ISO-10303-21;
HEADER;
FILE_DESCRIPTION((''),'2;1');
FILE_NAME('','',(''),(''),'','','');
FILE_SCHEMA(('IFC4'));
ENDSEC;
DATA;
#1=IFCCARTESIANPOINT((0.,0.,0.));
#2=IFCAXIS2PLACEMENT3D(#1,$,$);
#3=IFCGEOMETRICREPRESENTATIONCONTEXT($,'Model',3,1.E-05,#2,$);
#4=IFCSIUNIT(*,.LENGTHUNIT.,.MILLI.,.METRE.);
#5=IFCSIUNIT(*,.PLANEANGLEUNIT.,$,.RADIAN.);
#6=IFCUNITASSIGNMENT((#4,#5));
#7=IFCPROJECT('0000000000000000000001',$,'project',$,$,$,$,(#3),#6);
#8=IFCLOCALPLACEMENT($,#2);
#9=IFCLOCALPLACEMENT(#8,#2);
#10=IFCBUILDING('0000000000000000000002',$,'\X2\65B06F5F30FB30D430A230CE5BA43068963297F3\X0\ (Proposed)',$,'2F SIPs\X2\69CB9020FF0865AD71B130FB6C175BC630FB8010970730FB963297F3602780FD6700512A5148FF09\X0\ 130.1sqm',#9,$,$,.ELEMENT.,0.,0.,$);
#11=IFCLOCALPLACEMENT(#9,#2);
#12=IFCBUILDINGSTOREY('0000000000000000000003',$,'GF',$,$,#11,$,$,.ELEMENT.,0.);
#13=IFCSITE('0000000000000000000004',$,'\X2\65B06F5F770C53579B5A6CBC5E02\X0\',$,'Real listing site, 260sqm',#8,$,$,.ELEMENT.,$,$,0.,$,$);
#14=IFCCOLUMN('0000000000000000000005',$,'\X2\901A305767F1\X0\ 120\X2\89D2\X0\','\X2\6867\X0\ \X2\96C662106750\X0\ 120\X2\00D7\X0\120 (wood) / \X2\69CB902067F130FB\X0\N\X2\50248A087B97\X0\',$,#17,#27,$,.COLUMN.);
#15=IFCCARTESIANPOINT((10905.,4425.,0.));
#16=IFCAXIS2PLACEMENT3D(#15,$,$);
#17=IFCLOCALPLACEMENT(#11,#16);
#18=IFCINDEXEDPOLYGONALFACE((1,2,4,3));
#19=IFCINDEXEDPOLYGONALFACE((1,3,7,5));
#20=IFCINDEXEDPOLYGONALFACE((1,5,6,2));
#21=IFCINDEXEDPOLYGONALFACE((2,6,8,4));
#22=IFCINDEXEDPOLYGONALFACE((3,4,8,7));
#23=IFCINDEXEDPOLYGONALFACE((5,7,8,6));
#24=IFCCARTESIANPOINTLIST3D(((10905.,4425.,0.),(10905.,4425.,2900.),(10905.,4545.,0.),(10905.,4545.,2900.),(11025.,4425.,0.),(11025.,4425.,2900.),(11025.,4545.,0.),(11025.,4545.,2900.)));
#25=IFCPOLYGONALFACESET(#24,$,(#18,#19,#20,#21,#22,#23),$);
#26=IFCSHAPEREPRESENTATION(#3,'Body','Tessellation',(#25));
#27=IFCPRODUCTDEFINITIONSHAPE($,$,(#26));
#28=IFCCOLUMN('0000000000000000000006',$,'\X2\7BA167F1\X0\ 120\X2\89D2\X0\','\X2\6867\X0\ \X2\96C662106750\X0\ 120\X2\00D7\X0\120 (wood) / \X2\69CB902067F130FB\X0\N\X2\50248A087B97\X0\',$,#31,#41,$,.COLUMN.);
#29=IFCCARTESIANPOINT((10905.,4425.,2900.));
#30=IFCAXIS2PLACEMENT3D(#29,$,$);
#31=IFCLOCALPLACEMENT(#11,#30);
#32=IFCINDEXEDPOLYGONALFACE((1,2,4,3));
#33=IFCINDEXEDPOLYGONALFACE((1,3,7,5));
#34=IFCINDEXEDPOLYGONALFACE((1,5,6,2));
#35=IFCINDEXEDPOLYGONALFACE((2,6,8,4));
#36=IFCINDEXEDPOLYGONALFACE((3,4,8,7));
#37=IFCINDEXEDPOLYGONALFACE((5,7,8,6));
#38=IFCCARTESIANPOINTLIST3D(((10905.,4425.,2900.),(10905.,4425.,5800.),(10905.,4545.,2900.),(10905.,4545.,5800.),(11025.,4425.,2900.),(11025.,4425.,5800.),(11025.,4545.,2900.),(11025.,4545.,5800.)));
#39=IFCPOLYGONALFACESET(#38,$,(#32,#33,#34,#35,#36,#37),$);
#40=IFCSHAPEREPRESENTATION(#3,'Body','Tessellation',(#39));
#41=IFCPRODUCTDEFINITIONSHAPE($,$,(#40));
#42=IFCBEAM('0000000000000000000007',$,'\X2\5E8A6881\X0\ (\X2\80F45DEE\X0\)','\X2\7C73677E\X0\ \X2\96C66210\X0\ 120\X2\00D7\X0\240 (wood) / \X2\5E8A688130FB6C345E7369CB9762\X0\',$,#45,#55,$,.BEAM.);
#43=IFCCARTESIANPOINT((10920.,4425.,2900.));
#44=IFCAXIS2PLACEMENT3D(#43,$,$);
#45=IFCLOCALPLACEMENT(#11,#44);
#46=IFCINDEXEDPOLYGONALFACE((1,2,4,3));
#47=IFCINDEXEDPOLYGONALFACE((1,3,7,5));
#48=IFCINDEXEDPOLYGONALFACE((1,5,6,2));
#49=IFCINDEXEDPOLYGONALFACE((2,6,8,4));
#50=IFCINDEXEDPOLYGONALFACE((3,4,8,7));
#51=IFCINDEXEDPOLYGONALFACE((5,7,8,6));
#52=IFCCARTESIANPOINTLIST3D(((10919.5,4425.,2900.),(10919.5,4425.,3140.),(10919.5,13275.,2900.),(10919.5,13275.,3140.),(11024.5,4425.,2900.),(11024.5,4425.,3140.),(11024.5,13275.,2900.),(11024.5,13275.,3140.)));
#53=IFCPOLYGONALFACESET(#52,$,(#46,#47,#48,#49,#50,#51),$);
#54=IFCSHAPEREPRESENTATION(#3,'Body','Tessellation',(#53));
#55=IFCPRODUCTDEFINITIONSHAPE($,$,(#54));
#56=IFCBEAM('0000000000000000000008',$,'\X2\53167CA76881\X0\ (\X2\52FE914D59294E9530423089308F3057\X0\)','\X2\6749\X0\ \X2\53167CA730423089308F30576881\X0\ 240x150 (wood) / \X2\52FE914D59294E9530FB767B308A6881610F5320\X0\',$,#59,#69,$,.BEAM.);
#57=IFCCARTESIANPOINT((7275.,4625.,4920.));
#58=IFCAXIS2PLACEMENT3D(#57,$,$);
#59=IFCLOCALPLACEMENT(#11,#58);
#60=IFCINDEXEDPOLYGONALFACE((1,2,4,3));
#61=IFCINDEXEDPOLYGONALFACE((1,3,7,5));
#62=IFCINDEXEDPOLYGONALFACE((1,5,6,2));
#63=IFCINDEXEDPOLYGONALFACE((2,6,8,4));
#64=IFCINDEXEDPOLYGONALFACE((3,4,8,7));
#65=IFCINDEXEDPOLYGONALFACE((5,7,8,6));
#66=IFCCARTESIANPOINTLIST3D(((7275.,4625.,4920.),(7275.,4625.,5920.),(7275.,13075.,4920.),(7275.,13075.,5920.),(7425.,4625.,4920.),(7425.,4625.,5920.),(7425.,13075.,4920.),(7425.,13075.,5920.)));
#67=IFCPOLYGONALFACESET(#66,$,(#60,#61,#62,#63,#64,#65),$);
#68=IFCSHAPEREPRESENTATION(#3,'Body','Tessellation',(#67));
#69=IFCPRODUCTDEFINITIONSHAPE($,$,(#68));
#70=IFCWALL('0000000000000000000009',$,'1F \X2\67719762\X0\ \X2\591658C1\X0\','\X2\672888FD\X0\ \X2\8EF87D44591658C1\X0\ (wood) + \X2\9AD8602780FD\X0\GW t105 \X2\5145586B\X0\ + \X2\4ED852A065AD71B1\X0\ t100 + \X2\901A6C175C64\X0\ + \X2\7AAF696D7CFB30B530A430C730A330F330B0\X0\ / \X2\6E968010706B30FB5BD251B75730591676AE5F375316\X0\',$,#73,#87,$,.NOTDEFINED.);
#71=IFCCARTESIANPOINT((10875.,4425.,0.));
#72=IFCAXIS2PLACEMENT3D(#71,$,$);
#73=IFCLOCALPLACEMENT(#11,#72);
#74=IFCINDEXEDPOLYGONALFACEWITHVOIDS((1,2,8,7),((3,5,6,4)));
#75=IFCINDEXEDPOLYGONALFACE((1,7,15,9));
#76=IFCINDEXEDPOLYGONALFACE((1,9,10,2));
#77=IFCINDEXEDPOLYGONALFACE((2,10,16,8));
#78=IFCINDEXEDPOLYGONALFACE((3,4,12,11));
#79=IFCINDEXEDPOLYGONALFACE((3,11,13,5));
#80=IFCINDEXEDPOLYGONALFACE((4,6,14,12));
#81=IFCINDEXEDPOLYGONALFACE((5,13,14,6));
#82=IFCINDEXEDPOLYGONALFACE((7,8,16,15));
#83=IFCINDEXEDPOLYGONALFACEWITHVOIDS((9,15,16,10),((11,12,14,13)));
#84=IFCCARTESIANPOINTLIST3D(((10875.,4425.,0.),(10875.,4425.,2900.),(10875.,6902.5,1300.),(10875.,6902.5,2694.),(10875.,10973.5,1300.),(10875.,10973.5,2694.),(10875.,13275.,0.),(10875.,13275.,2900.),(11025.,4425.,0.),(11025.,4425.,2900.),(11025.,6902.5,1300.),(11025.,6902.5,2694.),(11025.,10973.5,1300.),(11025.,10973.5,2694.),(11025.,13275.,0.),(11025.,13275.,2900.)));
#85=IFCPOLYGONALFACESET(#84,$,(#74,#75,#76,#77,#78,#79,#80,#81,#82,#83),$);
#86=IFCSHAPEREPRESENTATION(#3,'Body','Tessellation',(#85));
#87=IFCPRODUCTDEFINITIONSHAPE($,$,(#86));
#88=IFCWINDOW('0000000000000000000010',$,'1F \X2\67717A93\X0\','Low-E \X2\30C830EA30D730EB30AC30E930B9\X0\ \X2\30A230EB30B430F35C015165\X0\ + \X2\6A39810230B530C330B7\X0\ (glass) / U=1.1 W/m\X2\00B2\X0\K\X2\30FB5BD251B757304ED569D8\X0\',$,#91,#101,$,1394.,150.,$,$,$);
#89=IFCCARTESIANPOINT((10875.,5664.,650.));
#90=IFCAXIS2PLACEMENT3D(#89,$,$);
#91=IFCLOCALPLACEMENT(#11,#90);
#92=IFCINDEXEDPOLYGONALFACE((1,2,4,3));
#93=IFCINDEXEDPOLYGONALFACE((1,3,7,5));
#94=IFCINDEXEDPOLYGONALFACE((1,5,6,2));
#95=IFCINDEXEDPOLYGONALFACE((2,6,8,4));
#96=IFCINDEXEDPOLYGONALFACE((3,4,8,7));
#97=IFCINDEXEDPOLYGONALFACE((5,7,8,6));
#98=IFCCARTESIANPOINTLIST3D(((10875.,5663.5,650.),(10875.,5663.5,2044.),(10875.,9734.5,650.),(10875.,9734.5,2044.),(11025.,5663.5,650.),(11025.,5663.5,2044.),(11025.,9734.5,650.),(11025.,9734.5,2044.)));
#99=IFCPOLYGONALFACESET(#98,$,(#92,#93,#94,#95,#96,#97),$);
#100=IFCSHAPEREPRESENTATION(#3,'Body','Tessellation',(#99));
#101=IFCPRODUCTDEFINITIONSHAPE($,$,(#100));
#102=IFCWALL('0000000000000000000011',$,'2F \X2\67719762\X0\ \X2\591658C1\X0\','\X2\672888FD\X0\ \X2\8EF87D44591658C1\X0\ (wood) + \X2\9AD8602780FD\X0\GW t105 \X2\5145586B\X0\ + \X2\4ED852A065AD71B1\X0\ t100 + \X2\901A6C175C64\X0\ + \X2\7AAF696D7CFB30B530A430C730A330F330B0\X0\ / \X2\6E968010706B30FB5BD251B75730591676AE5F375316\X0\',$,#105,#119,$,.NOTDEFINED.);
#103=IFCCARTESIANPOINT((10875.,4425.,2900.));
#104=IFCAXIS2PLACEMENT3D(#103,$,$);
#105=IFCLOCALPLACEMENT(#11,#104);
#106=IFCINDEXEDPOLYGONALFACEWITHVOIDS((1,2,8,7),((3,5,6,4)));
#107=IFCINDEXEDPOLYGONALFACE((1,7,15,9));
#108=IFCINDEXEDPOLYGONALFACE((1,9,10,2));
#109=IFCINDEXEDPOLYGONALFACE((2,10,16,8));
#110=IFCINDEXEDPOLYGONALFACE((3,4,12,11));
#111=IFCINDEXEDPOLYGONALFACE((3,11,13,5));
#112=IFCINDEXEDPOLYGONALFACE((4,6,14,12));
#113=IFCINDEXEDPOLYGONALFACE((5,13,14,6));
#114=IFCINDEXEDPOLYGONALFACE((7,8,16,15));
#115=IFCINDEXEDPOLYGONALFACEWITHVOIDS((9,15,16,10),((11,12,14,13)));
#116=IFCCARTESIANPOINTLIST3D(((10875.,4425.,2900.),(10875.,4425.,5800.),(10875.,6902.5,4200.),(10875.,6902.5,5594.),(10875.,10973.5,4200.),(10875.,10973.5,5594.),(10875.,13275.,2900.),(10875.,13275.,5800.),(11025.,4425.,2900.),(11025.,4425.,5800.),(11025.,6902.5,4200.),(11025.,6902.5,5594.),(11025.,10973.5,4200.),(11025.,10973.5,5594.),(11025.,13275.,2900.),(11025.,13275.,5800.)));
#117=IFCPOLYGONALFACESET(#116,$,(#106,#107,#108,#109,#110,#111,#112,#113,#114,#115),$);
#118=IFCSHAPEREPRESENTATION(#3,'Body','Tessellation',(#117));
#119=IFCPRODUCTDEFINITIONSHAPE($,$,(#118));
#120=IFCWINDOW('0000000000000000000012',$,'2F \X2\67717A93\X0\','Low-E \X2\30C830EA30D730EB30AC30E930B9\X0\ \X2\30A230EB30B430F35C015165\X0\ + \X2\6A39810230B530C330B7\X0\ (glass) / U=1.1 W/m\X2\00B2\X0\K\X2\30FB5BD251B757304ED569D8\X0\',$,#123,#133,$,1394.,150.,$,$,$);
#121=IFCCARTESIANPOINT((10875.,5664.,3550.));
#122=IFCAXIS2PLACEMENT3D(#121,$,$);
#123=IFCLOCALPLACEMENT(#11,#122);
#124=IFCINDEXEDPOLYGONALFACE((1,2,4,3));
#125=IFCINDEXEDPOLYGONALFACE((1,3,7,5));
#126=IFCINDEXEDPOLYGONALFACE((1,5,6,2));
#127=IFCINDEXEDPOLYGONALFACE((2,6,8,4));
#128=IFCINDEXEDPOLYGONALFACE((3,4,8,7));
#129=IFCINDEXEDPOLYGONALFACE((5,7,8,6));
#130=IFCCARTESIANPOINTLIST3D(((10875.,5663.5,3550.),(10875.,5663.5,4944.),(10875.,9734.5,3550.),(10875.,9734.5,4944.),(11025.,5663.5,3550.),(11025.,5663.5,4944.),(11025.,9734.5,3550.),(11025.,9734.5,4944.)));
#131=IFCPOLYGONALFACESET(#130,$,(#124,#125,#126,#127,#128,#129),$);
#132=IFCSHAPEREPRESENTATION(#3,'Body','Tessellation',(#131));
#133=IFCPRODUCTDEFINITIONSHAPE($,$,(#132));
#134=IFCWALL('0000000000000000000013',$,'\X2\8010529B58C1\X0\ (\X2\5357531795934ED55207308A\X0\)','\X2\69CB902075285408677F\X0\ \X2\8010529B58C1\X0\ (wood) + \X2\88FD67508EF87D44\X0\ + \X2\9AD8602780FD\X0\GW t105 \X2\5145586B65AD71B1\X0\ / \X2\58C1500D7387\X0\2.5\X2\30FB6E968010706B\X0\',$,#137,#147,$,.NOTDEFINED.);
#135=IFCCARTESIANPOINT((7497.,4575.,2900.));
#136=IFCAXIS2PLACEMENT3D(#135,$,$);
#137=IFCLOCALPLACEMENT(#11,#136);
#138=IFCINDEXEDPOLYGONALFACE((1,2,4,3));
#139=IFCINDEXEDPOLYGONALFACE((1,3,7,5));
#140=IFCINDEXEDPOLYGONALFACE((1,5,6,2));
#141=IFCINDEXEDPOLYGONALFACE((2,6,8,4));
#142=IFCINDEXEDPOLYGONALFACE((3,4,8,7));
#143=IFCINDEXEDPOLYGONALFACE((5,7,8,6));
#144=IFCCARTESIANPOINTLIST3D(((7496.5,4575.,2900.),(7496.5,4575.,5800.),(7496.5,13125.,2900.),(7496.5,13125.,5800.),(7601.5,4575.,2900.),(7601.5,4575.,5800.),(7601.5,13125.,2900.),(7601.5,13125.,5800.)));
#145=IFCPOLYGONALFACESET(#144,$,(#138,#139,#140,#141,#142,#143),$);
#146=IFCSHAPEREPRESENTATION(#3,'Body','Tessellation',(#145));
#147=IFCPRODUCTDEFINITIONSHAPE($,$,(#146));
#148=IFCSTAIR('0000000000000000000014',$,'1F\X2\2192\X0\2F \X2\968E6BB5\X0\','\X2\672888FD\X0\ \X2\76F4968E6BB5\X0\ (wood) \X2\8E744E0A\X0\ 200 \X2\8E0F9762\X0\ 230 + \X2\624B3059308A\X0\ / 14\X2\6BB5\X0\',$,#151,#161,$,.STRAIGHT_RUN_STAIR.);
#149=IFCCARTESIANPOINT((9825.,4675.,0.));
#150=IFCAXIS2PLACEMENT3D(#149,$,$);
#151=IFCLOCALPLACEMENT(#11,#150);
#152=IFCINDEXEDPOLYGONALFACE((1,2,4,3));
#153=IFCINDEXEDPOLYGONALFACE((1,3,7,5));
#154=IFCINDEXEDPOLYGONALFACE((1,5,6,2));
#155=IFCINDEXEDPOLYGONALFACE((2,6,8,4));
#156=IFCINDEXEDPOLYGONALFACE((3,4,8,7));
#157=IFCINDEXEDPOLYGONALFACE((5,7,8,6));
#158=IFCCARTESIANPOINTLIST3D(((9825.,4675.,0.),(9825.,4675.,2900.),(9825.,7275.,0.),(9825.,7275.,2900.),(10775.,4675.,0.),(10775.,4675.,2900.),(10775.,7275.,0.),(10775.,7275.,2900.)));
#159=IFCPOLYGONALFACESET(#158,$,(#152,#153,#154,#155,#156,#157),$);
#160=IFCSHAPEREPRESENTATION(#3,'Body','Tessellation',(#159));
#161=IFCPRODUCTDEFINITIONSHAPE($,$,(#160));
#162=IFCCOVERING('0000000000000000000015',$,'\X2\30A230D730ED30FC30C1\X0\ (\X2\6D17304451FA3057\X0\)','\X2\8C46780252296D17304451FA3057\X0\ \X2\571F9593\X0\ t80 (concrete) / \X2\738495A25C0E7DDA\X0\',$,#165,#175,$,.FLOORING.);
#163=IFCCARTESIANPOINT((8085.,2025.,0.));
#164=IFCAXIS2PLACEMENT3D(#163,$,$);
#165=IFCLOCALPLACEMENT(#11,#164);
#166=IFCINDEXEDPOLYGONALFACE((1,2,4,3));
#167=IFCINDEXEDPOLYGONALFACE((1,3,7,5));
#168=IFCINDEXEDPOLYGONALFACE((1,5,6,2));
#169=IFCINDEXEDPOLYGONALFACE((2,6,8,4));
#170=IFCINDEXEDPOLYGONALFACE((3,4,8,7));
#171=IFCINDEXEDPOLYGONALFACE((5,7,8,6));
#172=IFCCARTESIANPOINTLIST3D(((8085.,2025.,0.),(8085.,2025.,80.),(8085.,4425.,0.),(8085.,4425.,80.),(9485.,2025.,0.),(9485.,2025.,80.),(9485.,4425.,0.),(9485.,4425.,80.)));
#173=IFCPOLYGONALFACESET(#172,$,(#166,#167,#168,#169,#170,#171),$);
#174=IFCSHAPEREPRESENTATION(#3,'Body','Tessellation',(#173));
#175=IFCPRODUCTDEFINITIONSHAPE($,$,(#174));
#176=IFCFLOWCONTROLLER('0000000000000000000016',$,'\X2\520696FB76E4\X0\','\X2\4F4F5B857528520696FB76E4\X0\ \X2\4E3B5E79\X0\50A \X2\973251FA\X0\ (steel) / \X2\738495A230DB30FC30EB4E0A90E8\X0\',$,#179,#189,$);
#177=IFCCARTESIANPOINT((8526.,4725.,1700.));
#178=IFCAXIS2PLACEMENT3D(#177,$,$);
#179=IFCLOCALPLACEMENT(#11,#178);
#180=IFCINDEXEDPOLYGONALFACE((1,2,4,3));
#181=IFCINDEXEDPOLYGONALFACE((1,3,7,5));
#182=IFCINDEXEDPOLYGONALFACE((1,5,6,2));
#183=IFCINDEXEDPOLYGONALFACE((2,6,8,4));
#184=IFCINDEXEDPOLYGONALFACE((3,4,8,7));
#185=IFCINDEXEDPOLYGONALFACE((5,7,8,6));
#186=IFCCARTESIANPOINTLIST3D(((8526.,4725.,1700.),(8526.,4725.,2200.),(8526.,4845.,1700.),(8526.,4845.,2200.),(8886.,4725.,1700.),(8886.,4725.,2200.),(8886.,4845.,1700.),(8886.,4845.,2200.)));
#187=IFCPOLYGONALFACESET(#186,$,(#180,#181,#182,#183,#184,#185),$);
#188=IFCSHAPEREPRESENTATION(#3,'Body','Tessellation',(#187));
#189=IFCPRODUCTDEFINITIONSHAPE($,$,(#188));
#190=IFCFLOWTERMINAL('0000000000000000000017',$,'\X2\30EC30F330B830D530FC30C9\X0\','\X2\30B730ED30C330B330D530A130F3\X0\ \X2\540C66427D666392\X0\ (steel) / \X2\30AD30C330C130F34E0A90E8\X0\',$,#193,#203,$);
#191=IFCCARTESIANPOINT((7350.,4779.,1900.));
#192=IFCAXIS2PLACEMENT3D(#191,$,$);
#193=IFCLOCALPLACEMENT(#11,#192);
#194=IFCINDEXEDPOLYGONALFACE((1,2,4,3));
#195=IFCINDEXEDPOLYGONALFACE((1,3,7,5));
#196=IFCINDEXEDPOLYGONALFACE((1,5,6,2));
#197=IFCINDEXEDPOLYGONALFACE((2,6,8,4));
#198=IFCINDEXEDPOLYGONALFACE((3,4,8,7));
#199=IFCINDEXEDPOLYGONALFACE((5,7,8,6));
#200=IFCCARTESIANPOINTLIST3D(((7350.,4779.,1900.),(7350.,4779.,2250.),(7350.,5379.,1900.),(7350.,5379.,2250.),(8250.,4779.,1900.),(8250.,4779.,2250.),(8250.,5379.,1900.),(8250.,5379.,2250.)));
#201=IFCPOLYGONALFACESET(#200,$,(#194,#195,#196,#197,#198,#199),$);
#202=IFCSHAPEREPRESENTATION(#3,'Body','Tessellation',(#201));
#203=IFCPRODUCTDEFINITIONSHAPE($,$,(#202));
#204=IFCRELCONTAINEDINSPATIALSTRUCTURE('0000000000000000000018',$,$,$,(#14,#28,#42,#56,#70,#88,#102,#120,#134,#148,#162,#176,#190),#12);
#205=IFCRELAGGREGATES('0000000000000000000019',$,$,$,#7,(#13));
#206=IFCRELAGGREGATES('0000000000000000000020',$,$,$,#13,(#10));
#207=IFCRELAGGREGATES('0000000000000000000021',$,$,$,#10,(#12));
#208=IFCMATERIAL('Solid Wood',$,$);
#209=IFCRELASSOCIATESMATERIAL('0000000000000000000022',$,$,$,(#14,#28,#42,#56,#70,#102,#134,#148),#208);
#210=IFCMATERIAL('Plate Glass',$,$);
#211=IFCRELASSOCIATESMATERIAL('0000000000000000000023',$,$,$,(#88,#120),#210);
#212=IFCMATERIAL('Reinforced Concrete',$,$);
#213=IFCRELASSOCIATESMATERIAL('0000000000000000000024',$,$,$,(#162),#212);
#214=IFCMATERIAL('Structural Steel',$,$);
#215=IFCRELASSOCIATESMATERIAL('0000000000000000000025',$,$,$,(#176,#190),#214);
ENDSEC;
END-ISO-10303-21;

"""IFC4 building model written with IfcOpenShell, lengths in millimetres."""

from ifc_helpers import new_model, si_unit, frame, frame_2d, origin, place, context, project, spatial, rectangle, extrude, material, element, fill, save


model = new_model("IFC4")

# Units and contexts
model_context = context("Model", 3, precision=1e-05, world=origin())
ifc_project = project(units=[si_unit("LENGTHUNIT", "METRE", prefix="MILLI"), si_unit("PLANEANGLEUNIT", "RADIAN")], contexts=[model_context])

# Site, building, storey
site_placement = place(None, origin())
site = spatial("IfcSite", under=ifc_project, at=site_placement, Name="新潟県南魚沼市", ObjectType="Real listing site, 260sqm", CompositionType="ELEMENT", RefElevation=0.0)
building_placement = place(site_placement, origin())
building = spatial("IfcBuilding", under=site, at=building_placement, Name="新潟・ピアノ室と防音 (Proposed)", ObjectType="2F SIPs構造（断熱・気密・耐震・防音性能最優先） 130.1sqm", CompositionType="ELEMENT", ElevationOfRefHeight=0.0, ElevationOfTerrain=0.0)
storey_placement = place(building_placement, origin())
storey = spatial("IfcBuildingStorey", under=building, at=storey_placement, Name="GF", CompositionType="ELEMENT", Elevation=0.0)

# Columns
ifc_material_1 = material(Name="Solid Wood")
column_1_placement = place(storey_placement, frame((10905.0, 4425.0, 0.0)))
element("IfcColumn", 1, at=column_1_placement, inside=storey, material=ifc_material_1, Name="通し柱 120角", Description="桧 集成材 120×120 (wood) / 構造柱・N値計算", PredefinedType="COLUMN", context=model_context, shape_type="SweptSolid", body=[
    extrude(rectangle(XDim=120.0, YDim=120.0, at=frame_2d((60.0, 60.0))), frame((10905.0, 4425.0, 0.0)), (0.0, 0.0, 1.0), 2900.0),
])
column_2_placement = place(storey_placement, frame((10905.0, 4425.0, 2900.0)))
element("IfcColumn", 2, at=column_2_placement, inside=storey, material=ifc_material_1, Name="管柱 120角", Description="桧 集成材 120×120 (wood) / 構造柱・N値計算", PredefinedType="COLUMN", context=model_context, shape_type="SweptSolid", body=[
    extrude(rectangle(XDim=120.0, YDim=120.0, at=frame_2d((60.0, 60.0))), frame((10905.0, 4425.0, 2900.0)), (0.0, 0.0, 1.0), 2900.0),
])

# Beams
beam_1_placement = place(storey_placement, frame((10920.0, 4425.0, 2900.0)))
element("IfcBeam", 3, at=beam_1_placement, inside=storey, material=ifc_material_1, Name="床梁 (胴差)", Description="米松 集成 120×240 (wood) / 床梁・水平構面", PredefinedType="BEAM", context=model_context, shape_type="SweptSolid", body=[
    extrude(rectangle(XDim=105.0, YDim=8850.0, at=frame_2d((52.0, 4425.0))), frame((10920.0, 4425.0, 2900.0)), (0.0, 0.0, 1.0), 240.0),
])
beam_2_placement = place(storey_placement, frame((7275.0, 4625.0, 4920.0)))
element("IfcBeam", 4, at=beam_2_placement, inside=storey, material=ifc_material_1, Name="化粧梁 (勾配天井あらわし)", Description="杉 化粧あらわし梁 240x150 (wood) / 勾配天井・登り梁意匠", PredefinedType="BEAM", context=model_context, shape_type="SweptSolid", body=[
    extrude(rectangle(XDim=150.0, YDim=8450.0, at=frame_2d((75.0, 4225.0))), frame((7275.0, 4625.0, 4920.0)), (0.0, 0.0, 1.0), 1000.0),
])

# Wall, opening, window
wall_1_placement = place(storey_placement, frame((10875.0, 4425.0, 0.0)))
wall_1 = element("IfcWall", 5, at=wall_1_placement, inside=storey, material=ifc_material_1, Name="1F 東面 外壁", Description="木製 軸組外壁 (wood) + 高性能GW t105 充填 + 付加断熱 t100 + 通気層 + 窯業系サイディング / 準耐火・寒冷地外皮強化", PredefinedType="NOTDEFINED", context=model_context, shape_type="SweptSolid", body=[
    extrude(rectangle(XDim=150.0, YDim=8850.0, at=frame_2d((75.0, 4425.0))), frame((10875.0, 4425.0, 0.0)), (0.0, 0.0, 1.0), 2900.0),
])
opening_1_placement = place(storey_placement, frame((10875.0, 5664.0, 650.0)))
opening_1 = element("IfcOpeningElement", 6, at=opening_1_placement, cuts=wall_1, PredefinedType="NOTDEFINED", context=model_context, shape_type="SweptSolid", body=[
    extrude(rectangle(XDim=150.0, YDim=4071.0, at=frame_2d((75.0, 2035.0))), frame((10875.0, 5664.0, 650.0)), (0.0, 0.0, 1.0), 1394.0),
])
ifc_material_2 = material(Name="Plate Glass")
window_1_placement = place(storey_placement, frame((10875.0, 5664.0, 650.0)))
window_1 = element("IfcWindow", 7, at=window_1_placement, inside=storey, material=ifc_material_2, Name="1F 東窓", Description="Low-E トリプルガラス アルゴン封入 + 樹脂サッシ (glass) / U=1.1 W/m²K・寒冷地仕様", OverallHeight=1394.0, OverallWidth=150.0, context=model_context, shape_type="SweptSolid", body=[
    extrude(rectangle(XDim=150.0, YDim=4071.0, at=frame_2d((75.0, 2035.0))), frame((10875.0, 5664.0, 650.0)), (0.0, 0.0, 1.0), 1394.0),
])
fill(opening_1, window_1)

# Wall, opening, window
wall_2_placement = place(storey_placement, frame((10875.0, 4425.0, 2900.0)))
wall_2 = element("IfcWall", 8, at=wall_2_placement, inside=storey, material=ifc_material_1, Name="2F 東面 外壁", Description="木製 軸組外壁 (wood) + 高性能GW t105 充填 + 付加断熱 t100 + 通気層 + 窯業系サイディング / 準耐火・寒冷地外皮強化", PredefinedType="NOTDEFINED", context=model_context, shape_type="SweptSolid", body=[
    extrude(rectangle(XDim=150.0, YDim=8850.0, at=frame_2d((75.0, 4425.0))), frame((10875.0, 4425.0, 2900.0)), (0.0, 0.0, 1.0), 2900.0),
])
opening_2_placement = place(storey_placement, frame((10875.0, 5664.0, 3550.0)))
opening_2 = element("IfcOpeningElement", 9, at=opening_2_placement, cuts=wall_2, PredefinedType="NOTDEFINED", context=model_context, shape_type="SweptSolid", body=[
    extrude(rectangle(XDim=150.0, YDim=4071.0, at=frame_2d((75.0, 2035.0))), frame((10875.0, 5664.0, 3550.0)), (0.0, 0.0, 1.0), 1394.0),
])
window_2_placement = place(storey_placement, frame((10875.0, 5664.0, 3550.0)))
window_2 = element("IfcWindow", 10, at=window_2_placement, inside=storey, material=ifc_material_2, Name="2F 東窓", Description="Low-E トリプルガラス アルゴン封入 + 樹脂サッシ (glass) / U=1.1 W/m²K・寒冷地仕様", OverallHeight=1394.0, OverallWidth=150.0, context=model_context, shape_type="SweptSolid", body=[
    extrude(rectangle(XDim=150.0, YDim=4071.0, at=frame_2d((75.0, 2035.0))), frame((10875.0, 5664.0, 3550.0)), (0.0, 0.0, 1.0), 1394.0),
])
fill(opening_2, window_2)

# Wall
wall_3_placement = place(storey_placement, frame((7497.0, 4575.0, 2900.0)))
element("IfcWall", 11, at=wall_3_placement, inside=storey, material=ifc_material_1, Name="耐力壁 (南北間仕切り)", Description="構造用合板 耐力壁 (wood) + 製材軸組 + 高性能GW t105 充填断熱 / 壁倍率2.5・準耐火", PredefinedType="NOTDEFINED", context=model_context, shape_type="SweptSolid", body=[
    extrude(rectangle(XDim=105.0, YDim=8550.0, at=frame_2d((52.0, 4275.0))), frame((7497.0, 4575.0, 2900.0)), (0.0, 0.0, 1.0), 2900.0),
])

# Stair
stair_placement = place(storey_placement, frame((9825.0, 4675.0, 0.0)))
element("IfcStair", 12, at=stair_placement, inside=storey, material=ifc_material_1, Name="1F→2F 階段", Description="木製 直階段 (wood) 蹴上 200 踏面 230 + 手すり / 14段", PredefinedType="STRAIGHT_RUN_STAIR", context=model_context, shape_type="SweptSolid", body=[
    extrude(rectangle(XDim=950.0, YDim=2600.0, at=frame_2d((475.0, 1300.0))), frame((9825.0, 4675.0, 0.0)), (0.0, 0.0, 1.0), 2900.0),
])

# Covering
ifc_material_3 = material(Name="Reinforced Concrete")
covering_placement = place(storey_placement, frame((8085.0, 2025.0, 0.0)))
element("IfcCovering", 13, at=covering_placement, inside=storey, material=ifc_material_3, Name="アプローチ (洗い出し)", Description="豆砂利洗い出し 土間 t80 (concrete) / 玄関導線", PredefinedType="FLOORING", context=model_context, shape_type="SweptSolid", body=[
    extrude(rectangle(XDim=1400.0, YDim=2400.0, at=frame_2d((700.0, 1200.0))), frame((8085.0, 2025.0, 0.0)), (0.0, 0.0, 1.0), 80.0),
])

# Flow controller
ifc_material_4 = material(Name="Structural Steel")
flow_controller_placement = place(storey_placement, frame((8526.0, 4725.0, 1700.0)))
element("IfcFlowController", 14, at=flow_controller_placement, inside=storey, material=ifc_material_4, Name="分電盤", Description="住宅用分電盤 主幹50A 露出 (steel) / 玄関ホール上部", context=model_context, shape_type="SweptSolid", body=[
    extrude(rectangle(XDim=360.0, YDim=120.0, at=frame_2d((180.0, 60.0))), frame((8526.0, 4725.0, 1700.0)), (0.0, 0.0, 1.0), 500.0),
])

# Flow terminal
flow_terminal_1_placement = place(storey_placement, frame((7350.0, 4779.0, 1900.0)))
element("IfcFlowTerminal", 15, at=flow_terminal_1_placement, inside=storey, material=ifc_material_4, Name="レンジフード", Description="シロッコファン 同時給排 (steel) / キッチン上部", context=model_context, shape_type="SweptSolid", body=[
    extrude(rectangle(XDim=900.0, YDim=600.0, at=frame_2d((450.0, 300.0))), frame((7350.0, 4779.0, 1900.0)), (0.0, 0.0, 1.0), 350.0),
])

save(model, "model.ifc")
